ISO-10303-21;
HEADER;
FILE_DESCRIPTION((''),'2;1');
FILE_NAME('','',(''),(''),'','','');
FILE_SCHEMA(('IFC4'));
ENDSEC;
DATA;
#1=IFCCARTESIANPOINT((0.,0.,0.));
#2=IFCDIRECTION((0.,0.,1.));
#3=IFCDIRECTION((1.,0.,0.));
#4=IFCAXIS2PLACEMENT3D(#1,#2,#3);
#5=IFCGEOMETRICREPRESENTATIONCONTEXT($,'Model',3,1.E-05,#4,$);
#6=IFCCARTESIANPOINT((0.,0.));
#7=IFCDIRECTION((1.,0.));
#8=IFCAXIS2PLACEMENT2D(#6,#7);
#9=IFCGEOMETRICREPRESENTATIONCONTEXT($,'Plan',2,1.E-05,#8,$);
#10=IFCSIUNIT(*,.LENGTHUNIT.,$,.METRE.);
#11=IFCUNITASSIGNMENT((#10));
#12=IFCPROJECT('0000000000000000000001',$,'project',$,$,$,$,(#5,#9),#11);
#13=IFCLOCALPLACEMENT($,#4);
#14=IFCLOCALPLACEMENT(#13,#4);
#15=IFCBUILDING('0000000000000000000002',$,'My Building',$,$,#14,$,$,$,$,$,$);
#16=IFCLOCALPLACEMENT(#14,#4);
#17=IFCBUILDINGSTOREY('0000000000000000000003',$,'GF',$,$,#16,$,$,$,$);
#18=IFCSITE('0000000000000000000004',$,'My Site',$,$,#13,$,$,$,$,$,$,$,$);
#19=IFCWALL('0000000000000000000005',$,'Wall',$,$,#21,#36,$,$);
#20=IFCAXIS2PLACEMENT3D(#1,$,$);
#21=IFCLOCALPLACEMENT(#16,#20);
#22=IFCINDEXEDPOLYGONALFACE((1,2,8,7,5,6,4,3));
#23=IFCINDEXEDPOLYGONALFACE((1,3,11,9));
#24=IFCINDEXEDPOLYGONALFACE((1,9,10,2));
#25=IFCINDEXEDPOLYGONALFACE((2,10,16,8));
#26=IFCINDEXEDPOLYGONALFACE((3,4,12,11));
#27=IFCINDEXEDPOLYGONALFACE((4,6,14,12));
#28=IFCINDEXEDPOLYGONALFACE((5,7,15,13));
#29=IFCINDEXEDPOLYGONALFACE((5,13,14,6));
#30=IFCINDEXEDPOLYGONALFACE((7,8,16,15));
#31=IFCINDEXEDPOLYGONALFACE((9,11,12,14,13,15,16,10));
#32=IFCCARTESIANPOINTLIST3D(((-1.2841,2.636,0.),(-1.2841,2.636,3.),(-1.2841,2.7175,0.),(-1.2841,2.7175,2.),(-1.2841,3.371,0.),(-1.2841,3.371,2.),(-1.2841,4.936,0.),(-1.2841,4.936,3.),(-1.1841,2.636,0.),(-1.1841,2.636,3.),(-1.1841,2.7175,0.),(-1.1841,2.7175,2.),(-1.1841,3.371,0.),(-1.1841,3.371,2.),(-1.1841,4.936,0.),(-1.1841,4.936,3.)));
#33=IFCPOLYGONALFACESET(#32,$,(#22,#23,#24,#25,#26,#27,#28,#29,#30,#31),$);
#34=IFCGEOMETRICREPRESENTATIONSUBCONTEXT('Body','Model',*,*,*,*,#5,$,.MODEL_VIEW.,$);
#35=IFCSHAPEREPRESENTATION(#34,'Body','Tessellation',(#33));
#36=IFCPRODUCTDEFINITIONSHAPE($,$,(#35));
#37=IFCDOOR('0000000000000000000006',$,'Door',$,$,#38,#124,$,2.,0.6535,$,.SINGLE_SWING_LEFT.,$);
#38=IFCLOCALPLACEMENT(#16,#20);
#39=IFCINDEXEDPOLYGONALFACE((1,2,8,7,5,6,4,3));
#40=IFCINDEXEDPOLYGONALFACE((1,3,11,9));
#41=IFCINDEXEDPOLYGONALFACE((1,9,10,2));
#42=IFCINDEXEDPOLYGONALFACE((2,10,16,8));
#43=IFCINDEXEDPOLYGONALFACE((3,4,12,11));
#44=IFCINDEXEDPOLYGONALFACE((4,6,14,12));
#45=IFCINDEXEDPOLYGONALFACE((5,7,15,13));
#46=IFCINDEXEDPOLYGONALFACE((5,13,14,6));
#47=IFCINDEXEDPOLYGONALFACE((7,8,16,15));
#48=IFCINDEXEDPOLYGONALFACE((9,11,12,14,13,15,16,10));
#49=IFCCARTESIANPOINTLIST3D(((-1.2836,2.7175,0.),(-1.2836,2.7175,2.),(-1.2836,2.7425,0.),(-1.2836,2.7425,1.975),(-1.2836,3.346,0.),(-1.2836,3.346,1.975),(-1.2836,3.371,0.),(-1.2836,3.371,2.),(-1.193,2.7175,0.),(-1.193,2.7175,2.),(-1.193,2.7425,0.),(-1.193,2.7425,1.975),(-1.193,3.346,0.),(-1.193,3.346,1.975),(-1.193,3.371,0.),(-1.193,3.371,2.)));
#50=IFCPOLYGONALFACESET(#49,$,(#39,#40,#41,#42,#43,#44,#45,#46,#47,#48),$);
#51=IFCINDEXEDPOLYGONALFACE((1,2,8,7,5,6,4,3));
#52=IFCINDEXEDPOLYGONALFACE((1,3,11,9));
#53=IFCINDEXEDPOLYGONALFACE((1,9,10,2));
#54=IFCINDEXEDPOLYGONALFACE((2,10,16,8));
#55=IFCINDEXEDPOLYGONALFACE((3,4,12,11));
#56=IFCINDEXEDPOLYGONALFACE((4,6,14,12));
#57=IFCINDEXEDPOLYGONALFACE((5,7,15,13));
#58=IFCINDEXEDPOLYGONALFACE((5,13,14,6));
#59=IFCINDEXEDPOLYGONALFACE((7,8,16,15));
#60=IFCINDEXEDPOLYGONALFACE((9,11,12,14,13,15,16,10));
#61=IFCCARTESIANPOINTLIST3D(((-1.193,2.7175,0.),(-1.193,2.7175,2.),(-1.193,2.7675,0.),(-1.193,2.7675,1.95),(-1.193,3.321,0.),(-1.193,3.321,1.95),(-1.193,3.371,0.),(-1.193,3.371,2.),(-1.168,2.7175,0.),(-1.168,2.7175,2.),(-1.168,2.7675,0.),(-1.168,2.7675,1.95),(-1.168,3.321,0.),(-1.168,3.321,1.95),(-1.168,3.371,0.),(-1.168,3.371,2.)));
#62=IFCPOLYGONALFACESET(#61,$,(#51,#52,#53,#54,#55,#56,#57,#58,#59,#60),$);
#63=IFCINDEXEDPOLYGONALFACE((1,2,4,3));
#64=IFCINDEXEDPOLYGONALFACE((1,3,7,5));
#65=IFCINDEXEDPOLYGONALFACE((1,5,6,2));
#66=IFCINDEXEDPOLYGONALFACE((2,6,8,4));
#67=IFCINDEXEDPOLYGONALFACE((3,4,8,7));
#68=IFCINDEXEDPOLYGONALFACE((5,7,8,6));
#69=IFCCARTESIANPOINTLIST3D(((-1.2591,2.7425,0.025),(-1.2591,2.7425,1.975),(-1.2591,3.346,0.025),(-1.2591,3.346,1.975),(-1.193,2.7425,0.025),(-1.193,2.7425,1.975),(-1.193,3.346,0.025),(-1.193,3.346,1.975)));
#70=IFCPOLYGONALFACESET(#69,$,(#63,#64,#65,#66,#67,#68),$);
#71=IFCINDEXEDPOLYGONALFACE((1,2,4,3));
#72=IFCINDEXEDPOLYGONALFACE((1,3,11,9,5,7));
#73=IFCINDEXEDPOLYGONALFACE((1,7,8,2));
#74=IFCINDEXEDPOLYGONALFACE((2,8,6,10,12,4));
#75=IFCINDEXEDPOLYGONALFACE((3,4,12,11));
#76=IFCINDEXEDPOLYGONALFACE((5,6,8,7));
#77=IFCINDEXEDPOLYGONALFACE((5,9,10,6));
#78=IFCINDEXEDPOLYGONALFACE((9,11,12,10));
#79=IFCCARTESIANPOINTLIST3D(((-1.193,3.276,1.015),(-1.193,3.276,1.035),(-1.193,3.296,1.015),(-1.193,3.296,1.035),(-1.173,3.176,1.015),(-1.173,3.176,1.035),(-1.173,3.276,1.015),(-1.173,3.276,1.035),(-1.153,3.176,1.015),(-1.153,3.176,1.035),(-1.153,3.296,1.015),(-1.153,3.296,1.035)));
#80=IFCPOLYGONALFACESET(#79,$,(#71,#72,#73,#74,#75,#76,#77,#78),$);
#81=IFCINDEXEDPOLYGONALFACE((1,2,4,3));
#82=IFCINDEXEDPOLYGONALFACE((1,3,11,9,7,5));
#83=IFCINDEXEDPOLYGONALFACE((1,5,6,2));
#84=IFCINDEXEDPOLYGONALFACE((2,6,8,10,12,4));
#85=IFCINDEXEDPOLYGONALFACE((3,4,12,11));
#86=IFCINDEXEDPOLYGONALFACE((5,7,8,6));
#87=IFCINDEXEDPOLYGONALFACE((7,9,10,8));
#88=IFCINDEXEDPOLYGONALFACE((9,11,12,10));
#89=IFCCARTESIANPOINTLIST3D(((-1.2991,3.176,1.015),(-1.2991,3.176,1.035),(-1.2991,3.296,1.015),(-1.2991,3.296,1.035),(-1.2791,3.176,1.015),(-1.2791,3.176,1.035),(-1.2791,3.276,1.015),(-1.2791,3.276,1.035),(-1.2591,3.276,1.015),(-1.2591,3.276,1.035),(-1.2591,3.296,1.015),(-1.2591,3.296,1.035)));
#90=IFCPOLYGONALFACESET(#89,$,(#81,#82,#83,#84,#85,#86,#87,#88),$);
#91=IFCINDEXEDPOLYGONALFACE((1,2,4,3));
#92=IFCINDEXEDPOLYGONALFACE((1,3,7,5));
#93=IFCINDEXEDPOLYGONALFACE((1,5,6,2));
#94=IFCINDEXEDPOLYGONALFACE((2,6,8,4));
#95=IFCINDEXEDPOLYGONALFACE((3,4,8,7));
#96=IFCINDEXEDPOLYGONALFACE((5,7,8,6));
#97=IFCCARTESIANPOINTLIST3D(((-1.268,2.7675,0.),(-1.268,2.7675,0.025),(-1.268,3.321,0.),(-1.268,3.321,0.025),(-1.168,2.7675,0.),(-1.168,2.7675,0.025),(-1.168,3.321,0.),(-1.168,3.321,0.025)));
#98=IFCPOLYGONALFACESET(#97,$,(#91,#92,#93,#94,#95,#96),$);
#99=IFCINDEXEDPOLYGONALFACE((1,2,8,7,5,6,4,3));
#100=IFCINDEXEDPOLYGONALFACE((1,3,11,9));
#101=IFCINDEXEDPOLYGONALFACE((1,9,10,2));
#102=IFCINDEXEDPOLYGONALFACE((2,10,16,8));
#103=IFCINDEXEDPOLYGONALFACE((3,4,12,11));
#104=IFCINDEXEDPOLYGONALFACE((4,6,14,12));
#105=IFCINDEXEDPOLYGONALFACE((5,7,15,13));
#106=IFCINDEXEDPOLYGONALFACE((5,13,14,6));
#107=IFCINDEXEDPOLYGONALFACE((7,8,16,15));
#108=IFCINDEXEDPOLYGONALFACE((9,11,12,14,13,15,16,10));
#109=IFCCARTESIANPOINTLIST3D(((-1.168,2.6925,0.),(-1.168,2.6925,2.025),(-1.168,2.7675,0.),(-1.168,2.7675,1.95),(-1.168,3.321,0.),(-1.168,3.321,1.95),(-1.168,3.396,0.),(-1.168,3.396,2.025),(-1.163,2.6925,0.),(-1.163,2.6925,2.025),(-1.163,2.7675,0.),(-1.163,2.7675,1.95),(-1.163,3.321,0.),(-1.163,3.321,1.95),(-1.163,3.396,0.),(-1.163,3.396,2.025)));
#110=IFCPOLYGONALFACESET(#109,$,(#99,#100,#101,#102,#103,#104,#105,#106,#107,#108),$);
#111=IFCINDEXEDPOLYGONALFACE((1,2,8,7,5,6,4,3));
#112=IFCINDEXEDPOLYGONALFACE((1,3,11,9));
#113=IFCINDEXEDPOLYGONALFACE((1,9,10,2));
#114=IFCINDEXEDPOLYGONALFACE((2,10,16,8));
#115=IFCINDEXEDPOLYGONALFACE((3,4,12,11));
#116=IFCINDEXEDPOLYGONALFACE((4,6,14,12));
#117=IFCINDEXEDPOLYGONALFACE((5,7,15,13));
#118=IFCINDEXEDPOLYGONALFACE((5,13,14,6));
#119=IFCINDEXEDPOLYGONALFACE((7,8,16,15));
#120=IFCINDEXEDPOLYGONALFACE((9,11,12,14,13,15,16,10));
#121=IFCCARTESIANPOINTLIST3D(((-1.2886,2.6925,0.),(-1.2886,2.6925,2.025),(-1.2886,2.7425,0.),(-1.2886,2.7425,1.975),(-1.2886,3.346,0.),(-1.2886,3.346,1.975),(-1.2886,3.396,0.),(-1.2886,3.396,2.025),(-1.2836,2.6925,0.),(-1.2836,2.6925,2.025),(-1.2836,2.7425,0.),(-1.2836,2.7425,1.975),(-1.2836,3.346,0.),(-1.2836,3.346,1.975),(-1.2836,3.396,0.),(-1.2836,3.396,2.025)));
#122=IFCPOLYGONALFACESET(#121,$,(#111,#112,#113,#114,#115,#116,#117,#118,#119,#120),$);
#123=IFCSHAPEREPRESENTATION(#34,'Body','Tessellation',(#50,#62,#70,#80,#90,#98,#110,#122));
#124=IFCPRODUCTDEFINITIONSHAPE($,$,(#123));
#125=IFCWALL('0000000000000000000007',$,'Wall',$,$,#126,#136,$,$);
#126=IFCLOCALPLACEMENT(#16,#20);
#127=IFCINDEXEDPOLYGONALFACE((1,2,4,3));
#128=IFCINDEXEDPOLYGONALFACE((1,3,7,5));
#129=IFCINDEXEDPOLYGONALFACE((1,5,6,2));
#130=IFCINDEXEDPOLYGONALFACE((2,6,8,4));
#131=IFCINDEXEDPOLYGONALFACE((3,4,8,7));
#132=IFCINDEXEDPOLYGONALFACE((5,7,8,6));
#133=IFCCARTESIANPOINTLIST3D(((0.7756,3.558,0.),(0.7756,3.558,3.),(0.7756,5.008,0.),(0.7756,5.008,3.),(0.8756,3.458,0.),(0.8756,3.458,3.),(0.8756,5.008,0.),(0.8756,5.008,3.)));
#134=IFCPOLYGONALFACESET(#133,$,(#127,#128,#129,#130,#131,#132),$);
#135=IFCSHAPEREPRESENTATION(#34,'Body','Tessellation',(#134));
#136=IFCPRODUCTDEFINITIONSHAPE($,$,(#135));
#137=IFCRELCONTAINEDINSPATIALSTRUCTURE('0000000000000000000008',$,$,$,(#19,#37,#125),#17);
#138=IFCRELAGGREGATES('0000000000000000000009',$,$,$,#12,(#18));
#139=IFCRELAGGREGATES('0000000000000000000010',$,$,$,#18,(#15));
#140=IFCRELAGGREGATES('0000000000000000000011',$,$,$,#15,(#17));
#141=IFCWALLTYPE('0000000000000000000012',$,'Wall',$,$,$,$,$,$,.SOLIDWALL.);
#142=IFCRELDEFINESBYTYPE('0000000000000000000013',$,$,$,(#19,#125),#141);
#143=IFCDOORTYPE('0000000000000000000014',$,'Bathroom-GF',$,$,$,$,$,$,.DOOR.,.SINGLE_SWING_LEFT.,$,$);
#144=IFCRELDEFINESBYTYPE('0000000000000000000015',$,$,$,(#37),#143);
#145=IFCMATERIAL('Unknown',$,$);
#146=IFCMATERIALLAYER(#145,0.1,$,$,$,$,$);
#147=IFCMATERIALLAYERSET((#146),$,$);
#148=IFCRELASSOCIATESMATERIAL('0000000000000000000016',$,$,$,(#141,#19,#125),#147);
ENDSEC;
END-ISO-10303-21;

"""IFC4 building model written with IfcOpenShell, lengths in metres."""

from ifc_helpers import new_model, entity, si_unit, frame, origin_with_axes, origin_2d_with_axis, place, context, subcontext, project, spatial, line, indexed_curve, outline, extrude, shape, source, transform, mapped, material, layer, layer_set, layer_usage, type_object, type_shapes, element, fill, save


model = new_model("IFC4")

# Units and contexts
model_context = context("Model", 3, precision=1e-05, world=origin_with_axes())
plan_context = context("Plan", 2, precision=1e-05, world=origin_2d_with_axis())
body_context_1 = subcontext(model_context, "Body", "Model", "MODEL_VIEW")
body_context_2 = subcontext(plan_context, "Body", "Plan", "PLAN_VIEW")
ifc_project = project(units=[si_unit("LENGTHUNIT", "METRE")], contexts=[model_context, plan_context])

# Site, building, storey
site_placement = place(None, origin_with_axes())
site = spatial("IfcSite", under=ifc_project, at=site_placement, Name="My Site")
building_placement = place(site_placement, origin_with_axes())
building = spatial("IfcBuilding", under=site, at=building_placement, Name="My Building")
storey_placement = place(building_placement, origin_with_axes())
storey = spatial("IfcBuildingStorey", under=building, at=storey_placement, Name="GF")

# Shared definitions
ifc_material = material(Name="Unknown")

# Shared definitions
ifc_layer_1 = layer(ifc_material, 0.1)
ifc_layer_set_1 = layer_set([ifc_layer_1])
wall_type = type_object("IfcWallType", Name="Wall", PredefinedType="SOLIDWALL", material=ifc_layer_set_1)

# Wall, opening, door
ifc_layer_usage_1 = layer_usage(ifc_layer_set_1, "AXIS2", "POSITIVE", 0.0)
wall_1_placement = place(storey_placement, frame((-1.1841, 2.636, 0.0), z_axis=(0.0, 0.0, 1.0), x_axis=(0.0, 1.0, 0.0)))
wall_1 = element("IfcWall", 1, at=wall_1_placement, inside=storey, type_object=wall_type, material=ifc_layer_usage_1, Name="Wall", context=body_context_1, shape_type="SweptSolid", body=[
    extrude(outline(indexed_curve([(0.0, 0.0), (0.0, 0.1), (2.3, 0.1), (2.3, 0.0)], segments=[line(1, 2, 3, 4, 1)])), origin_with_axes(), (0.0, 0.0, 1.0), 3.0),
])
shared_shape_1 = source(origin_with_axes(), body_context_1, "Body", "SweptSolid", [
    extrude(outline(indexed_curve([(0.0, 0.0), (0.6535, 0.0), (0.6535, 2.0), (0.0, 2.0)], segments=[line(1, 2, 3, 4, 1)])), frame((0.0, -0.6, 0.0), z_axis=(0.0, -1.0, 0.0), x_axis=(1.0, 0.0, 0.0)), (0.0, 0.0, -1.0), 1.2),
])
opening_1_placement = place(wall_1_placement, frame((0.0815, -0.0161, 0.0), z_axis=(0.0, 0.0, 1.0), x_axis=(1.0, 0.0, 0.0)))
opening_1 = element("IfcOpeningElement", 2, at=opening_1_placement, cuts=wall_1, PredefinedType="OPENING", context=body_context_1, shape_type="MappedRepresentation", body=[
    mapped(shared_shape_1, transform((0.0, 0.0, 0.0), x_axis=(1.0, 0.0, 0.0), y_axis=(0.0, 1.0, 0.0), z_axis=(0.0, 0.0, 1.0), scale=1.0)),
])
door_type_1 = type_object("IfcDoorType", Name="Bathroom-GF", OperationType="SINGLE_SWING_LEFT", PredefinedType="DOOR")
shared_shape_2 = source(origin_with_axes(), body_context_1, "Body", "SweptSolid", [
    extrude(outline(indexed_curve([(0.0, 0.0), (0.0, 2.0), (0.6535, 2.0), (0.6535, 0.0), (0.6285, 0.0), (0.6285, 1.975), (0.025, 1.975), (0.025, 0.0)], segments=[line(1, 2, 3, 4, 5, 6, 7, 8, 1)])), frame((0.0, 0.025, 0.0), z_axis=(0.0, -1.0, 0.0), x_axis=(1.0, 0.0, 0.0)), (0.0, 0.0, -1.0), 0.0906),
    extrude(outline(indexed_curve([(0.0, 0.0), (0.0, 2.0), (0.6535, 2.0), (0.6535, 0.0), (0.6035, 0.0), (0.6035, 1.95), (0.05, 1.95), (0.05, 0.0)], segments=[line(1, 2, 3, 4, 5, 6, 7, 8, 1)])), frame((0.0, 0.0, 0.0), z_axis=(0.0, -1.0, 0.0), x_axis=(1.0, 0.0, 0.0)), (0.0, 0.0, -1.0), 0.025),
    extrude(outline(indexed_curve([(0.0, 0.0), (0.6035, 0.0), (0.6035, 0.0661), (0.0, 0.0661)], segments=[line(1, 2, 3, 4, 1)])), frame((0.025, 0.025, 0.025), z_axis=(0.0, 0.0, 1.0), x_axis=(1.0, 0.0, 0.0)), (0.0, 0.0, 1.0), 1.95),
    extrude(outline(indexed_curve([(0.0, 0.0), (0.0, -0.04), (-0.12, -0.04), (-0.12, -0.02), (-0.02, -0.02), (-0.02, 0.0)], segments=[line(1, 2, 3, 4, 5, 6, 1)])), frame((0.5785, 0.025, 1.015), z_axis=(0.0, 0.0, 1.0), x_axis=(1.0, 0.0, 0.0)), (0.0, 0.0, 1.0), 0.02),
    extrude(outline(indexed_curve([(0.0, 0.0), (0.0, 0.04), (-0.12, 0.04), (-0.12, 0.02), (-0.02, 0.02), (-0.02, 0.0)], segments=[line(1, 2, 3, 4, 5, 6, 1)])), frame((0.5785, 0.0911, 1.015), z_axis=(0.0, 0.0, 1.0), x_axis=(1.0, 0.0, 0.0)), (0.0, 0.0, 1.0), 0.02),
    extrude(outline(indexed_curve([(0.0, 0.0), (0.5535, 0.0), (0.5535, 0.1), (0.0, 0.1)], segments=[line(1, 2, 3, 4, 1)])), frame((0.05, 0.0, 0.0), z_axis=(0.0, 0.0, 1.0), x_axis=(1.0, 0.0, 0.0)), (0.0, 0.0, 1.0), 0.025),
    extrude(outline(indexed_curve([(0.0, 0.0), (0.0, 2.025), (0.7035, 2.025), (0.7035, 0.0), (0.6285, 0.0), (0.6285, 1.95), (0.075, 1.95), (0.075, 0.0)], segments=[line(1, 2, 3, 4, 5, 6, 7, 8, 1)])), frame((-0.025, -0.005, 0.0), z_axis=(0.0, -1.0, 0.0), x_axis=(1.0, 0.0, 0.0)), (0.0, 0.0, -1.0), 0.005),
    extrude(outline(indexed_curve([(0.0, 0.0), (0.0, 2.025), (0.7035, 2.025), (0.7035, 0.0), (0.6535, 0.0), (0.6535, 1.975), (0.05, 1.975), (0.05, 0.0)], segments=[line(1, 2, 3, 4, 5, 6, 7, 8, 1)])), frame((-0.025, 0.1156, 0.0), z_axis=(0.0, -1.0, 0.0), x_axis=(1.0, 0.0, 0.0)), (0.0, 0.0, -1.0), 0.005),
])
shared_shape_3 = source(origin_with_axes(), body_context_2, "Body", "Curve2D", [
    entity("IfcIndexedPolyCurve", entity("IfcCartesianPointList2D", [[0.0, 0.0], [0.0, 0.1156], [0.025, 0.1156], [0.025, 0.025], [0.05, 0.025], [0.05, 0.0]]), [entity("IfcLineIndex", [1, 2, 3, 4, 5, 6, 1])]),
    entity("IfcIndexedPolyCurve", entity("IfcCartesianPointList2D", [[0.6535, 0.0], [0.6535, 0.1156], [0.6285, 0.1156], [0.6285, 0.025], [0.6035, 0.025], [0.6035, 0.0]]), [entity("IfcLineIndex", [1, 2, 3, 4, 5, 6, 1])]),
    entity("IfcTrimmedCurve", entity("IfcEllipse", entity("IfcAxis2Placement2D", entity("IfcCartesianPoint", [0.0911, 0.1156]), entity("IfcDirection", [1.0, 0.0])), 0.5374, 0.6035), [entity("IfcCartesianPoint", [0.6285, 0.1156])], [entity("IfcCartesianPoint", [0.0911, 0.7191])], True, "CARTESIAN"),
    entity("IfcIndexedPolyCurve", entity("IfcCartesianPointList2D", [[0.025, 0.1156], [0.0911, 0.1156], [0.0911, 0.7191], [0.025, 0.7191]]), [entity("IfcLineIndex", [1, 2, 3, 4, 1])]),
])
type_shapes(door_type_1, [shared_shape_2, shared_shape_3])
door_1_placement = place(opening_1_placement, origin_with_axes())
door_1 = element("IfcDoor", 3, at=door_1_placement, inside=storey, type_object=door_type_1, Name="Door", OperationType="SINGLE_SWING_LEFT", OverallHeight=2.0, OverallWidth=0.6535, shapes=[
    shape(body_context_1, "Body", "MappedRepresentation", [mapped(shared_shape_2, transform((0.0, 0.0, 0.0), x_axis=(1.0, 0.0, 0.0), y_axis=(0.0, 1.0, 0.0), z_axis=(0.0, 0.0, 1.0), scale=1.0))]),
    shape(body_context_2, "Body", "MappedRepresentation", [mapped(shared_shape_3, transform((0.0, 0.0, 0.0), x_axis=(1.0, 0.0, 0.0), y_axis=(0.0, 1.0, 0.0), z_axis=(0.0, 0.0, 1.0), scale=1.0))]),
])
fill(opening_1, door_1)

# Wall
ifc_layer_usage_2 = layer_usage(ifc_layer_set_1, "AXIS2", "POSITIVE", 0.0)
wall_2_placement = place(storey_placement, frame((0.7756, 5.008, 0.0), z_axis=(0.0, 0.0, 1.0), x_axis=(0.0, -1.0, 0.0)))
element("IfcWall", 4, at=wall_2_placement, inside=storey, type_object=wall_type, material=ifc_layer_usage_2, Name="Wall", context=body_context_1, shape_type="SweptSolid", body=[
    extrude(outline(indexed_curve([(0.0, 0.0), (0.0, 0.1), (1.55, 0.1), (1.45, 0.0)], segments=[line(1, 2, 3, 4, 1)])), origin_with_axes(), (0.0, 0.0, 1.0), 3.0),
])

save(model, "model.ifc")
